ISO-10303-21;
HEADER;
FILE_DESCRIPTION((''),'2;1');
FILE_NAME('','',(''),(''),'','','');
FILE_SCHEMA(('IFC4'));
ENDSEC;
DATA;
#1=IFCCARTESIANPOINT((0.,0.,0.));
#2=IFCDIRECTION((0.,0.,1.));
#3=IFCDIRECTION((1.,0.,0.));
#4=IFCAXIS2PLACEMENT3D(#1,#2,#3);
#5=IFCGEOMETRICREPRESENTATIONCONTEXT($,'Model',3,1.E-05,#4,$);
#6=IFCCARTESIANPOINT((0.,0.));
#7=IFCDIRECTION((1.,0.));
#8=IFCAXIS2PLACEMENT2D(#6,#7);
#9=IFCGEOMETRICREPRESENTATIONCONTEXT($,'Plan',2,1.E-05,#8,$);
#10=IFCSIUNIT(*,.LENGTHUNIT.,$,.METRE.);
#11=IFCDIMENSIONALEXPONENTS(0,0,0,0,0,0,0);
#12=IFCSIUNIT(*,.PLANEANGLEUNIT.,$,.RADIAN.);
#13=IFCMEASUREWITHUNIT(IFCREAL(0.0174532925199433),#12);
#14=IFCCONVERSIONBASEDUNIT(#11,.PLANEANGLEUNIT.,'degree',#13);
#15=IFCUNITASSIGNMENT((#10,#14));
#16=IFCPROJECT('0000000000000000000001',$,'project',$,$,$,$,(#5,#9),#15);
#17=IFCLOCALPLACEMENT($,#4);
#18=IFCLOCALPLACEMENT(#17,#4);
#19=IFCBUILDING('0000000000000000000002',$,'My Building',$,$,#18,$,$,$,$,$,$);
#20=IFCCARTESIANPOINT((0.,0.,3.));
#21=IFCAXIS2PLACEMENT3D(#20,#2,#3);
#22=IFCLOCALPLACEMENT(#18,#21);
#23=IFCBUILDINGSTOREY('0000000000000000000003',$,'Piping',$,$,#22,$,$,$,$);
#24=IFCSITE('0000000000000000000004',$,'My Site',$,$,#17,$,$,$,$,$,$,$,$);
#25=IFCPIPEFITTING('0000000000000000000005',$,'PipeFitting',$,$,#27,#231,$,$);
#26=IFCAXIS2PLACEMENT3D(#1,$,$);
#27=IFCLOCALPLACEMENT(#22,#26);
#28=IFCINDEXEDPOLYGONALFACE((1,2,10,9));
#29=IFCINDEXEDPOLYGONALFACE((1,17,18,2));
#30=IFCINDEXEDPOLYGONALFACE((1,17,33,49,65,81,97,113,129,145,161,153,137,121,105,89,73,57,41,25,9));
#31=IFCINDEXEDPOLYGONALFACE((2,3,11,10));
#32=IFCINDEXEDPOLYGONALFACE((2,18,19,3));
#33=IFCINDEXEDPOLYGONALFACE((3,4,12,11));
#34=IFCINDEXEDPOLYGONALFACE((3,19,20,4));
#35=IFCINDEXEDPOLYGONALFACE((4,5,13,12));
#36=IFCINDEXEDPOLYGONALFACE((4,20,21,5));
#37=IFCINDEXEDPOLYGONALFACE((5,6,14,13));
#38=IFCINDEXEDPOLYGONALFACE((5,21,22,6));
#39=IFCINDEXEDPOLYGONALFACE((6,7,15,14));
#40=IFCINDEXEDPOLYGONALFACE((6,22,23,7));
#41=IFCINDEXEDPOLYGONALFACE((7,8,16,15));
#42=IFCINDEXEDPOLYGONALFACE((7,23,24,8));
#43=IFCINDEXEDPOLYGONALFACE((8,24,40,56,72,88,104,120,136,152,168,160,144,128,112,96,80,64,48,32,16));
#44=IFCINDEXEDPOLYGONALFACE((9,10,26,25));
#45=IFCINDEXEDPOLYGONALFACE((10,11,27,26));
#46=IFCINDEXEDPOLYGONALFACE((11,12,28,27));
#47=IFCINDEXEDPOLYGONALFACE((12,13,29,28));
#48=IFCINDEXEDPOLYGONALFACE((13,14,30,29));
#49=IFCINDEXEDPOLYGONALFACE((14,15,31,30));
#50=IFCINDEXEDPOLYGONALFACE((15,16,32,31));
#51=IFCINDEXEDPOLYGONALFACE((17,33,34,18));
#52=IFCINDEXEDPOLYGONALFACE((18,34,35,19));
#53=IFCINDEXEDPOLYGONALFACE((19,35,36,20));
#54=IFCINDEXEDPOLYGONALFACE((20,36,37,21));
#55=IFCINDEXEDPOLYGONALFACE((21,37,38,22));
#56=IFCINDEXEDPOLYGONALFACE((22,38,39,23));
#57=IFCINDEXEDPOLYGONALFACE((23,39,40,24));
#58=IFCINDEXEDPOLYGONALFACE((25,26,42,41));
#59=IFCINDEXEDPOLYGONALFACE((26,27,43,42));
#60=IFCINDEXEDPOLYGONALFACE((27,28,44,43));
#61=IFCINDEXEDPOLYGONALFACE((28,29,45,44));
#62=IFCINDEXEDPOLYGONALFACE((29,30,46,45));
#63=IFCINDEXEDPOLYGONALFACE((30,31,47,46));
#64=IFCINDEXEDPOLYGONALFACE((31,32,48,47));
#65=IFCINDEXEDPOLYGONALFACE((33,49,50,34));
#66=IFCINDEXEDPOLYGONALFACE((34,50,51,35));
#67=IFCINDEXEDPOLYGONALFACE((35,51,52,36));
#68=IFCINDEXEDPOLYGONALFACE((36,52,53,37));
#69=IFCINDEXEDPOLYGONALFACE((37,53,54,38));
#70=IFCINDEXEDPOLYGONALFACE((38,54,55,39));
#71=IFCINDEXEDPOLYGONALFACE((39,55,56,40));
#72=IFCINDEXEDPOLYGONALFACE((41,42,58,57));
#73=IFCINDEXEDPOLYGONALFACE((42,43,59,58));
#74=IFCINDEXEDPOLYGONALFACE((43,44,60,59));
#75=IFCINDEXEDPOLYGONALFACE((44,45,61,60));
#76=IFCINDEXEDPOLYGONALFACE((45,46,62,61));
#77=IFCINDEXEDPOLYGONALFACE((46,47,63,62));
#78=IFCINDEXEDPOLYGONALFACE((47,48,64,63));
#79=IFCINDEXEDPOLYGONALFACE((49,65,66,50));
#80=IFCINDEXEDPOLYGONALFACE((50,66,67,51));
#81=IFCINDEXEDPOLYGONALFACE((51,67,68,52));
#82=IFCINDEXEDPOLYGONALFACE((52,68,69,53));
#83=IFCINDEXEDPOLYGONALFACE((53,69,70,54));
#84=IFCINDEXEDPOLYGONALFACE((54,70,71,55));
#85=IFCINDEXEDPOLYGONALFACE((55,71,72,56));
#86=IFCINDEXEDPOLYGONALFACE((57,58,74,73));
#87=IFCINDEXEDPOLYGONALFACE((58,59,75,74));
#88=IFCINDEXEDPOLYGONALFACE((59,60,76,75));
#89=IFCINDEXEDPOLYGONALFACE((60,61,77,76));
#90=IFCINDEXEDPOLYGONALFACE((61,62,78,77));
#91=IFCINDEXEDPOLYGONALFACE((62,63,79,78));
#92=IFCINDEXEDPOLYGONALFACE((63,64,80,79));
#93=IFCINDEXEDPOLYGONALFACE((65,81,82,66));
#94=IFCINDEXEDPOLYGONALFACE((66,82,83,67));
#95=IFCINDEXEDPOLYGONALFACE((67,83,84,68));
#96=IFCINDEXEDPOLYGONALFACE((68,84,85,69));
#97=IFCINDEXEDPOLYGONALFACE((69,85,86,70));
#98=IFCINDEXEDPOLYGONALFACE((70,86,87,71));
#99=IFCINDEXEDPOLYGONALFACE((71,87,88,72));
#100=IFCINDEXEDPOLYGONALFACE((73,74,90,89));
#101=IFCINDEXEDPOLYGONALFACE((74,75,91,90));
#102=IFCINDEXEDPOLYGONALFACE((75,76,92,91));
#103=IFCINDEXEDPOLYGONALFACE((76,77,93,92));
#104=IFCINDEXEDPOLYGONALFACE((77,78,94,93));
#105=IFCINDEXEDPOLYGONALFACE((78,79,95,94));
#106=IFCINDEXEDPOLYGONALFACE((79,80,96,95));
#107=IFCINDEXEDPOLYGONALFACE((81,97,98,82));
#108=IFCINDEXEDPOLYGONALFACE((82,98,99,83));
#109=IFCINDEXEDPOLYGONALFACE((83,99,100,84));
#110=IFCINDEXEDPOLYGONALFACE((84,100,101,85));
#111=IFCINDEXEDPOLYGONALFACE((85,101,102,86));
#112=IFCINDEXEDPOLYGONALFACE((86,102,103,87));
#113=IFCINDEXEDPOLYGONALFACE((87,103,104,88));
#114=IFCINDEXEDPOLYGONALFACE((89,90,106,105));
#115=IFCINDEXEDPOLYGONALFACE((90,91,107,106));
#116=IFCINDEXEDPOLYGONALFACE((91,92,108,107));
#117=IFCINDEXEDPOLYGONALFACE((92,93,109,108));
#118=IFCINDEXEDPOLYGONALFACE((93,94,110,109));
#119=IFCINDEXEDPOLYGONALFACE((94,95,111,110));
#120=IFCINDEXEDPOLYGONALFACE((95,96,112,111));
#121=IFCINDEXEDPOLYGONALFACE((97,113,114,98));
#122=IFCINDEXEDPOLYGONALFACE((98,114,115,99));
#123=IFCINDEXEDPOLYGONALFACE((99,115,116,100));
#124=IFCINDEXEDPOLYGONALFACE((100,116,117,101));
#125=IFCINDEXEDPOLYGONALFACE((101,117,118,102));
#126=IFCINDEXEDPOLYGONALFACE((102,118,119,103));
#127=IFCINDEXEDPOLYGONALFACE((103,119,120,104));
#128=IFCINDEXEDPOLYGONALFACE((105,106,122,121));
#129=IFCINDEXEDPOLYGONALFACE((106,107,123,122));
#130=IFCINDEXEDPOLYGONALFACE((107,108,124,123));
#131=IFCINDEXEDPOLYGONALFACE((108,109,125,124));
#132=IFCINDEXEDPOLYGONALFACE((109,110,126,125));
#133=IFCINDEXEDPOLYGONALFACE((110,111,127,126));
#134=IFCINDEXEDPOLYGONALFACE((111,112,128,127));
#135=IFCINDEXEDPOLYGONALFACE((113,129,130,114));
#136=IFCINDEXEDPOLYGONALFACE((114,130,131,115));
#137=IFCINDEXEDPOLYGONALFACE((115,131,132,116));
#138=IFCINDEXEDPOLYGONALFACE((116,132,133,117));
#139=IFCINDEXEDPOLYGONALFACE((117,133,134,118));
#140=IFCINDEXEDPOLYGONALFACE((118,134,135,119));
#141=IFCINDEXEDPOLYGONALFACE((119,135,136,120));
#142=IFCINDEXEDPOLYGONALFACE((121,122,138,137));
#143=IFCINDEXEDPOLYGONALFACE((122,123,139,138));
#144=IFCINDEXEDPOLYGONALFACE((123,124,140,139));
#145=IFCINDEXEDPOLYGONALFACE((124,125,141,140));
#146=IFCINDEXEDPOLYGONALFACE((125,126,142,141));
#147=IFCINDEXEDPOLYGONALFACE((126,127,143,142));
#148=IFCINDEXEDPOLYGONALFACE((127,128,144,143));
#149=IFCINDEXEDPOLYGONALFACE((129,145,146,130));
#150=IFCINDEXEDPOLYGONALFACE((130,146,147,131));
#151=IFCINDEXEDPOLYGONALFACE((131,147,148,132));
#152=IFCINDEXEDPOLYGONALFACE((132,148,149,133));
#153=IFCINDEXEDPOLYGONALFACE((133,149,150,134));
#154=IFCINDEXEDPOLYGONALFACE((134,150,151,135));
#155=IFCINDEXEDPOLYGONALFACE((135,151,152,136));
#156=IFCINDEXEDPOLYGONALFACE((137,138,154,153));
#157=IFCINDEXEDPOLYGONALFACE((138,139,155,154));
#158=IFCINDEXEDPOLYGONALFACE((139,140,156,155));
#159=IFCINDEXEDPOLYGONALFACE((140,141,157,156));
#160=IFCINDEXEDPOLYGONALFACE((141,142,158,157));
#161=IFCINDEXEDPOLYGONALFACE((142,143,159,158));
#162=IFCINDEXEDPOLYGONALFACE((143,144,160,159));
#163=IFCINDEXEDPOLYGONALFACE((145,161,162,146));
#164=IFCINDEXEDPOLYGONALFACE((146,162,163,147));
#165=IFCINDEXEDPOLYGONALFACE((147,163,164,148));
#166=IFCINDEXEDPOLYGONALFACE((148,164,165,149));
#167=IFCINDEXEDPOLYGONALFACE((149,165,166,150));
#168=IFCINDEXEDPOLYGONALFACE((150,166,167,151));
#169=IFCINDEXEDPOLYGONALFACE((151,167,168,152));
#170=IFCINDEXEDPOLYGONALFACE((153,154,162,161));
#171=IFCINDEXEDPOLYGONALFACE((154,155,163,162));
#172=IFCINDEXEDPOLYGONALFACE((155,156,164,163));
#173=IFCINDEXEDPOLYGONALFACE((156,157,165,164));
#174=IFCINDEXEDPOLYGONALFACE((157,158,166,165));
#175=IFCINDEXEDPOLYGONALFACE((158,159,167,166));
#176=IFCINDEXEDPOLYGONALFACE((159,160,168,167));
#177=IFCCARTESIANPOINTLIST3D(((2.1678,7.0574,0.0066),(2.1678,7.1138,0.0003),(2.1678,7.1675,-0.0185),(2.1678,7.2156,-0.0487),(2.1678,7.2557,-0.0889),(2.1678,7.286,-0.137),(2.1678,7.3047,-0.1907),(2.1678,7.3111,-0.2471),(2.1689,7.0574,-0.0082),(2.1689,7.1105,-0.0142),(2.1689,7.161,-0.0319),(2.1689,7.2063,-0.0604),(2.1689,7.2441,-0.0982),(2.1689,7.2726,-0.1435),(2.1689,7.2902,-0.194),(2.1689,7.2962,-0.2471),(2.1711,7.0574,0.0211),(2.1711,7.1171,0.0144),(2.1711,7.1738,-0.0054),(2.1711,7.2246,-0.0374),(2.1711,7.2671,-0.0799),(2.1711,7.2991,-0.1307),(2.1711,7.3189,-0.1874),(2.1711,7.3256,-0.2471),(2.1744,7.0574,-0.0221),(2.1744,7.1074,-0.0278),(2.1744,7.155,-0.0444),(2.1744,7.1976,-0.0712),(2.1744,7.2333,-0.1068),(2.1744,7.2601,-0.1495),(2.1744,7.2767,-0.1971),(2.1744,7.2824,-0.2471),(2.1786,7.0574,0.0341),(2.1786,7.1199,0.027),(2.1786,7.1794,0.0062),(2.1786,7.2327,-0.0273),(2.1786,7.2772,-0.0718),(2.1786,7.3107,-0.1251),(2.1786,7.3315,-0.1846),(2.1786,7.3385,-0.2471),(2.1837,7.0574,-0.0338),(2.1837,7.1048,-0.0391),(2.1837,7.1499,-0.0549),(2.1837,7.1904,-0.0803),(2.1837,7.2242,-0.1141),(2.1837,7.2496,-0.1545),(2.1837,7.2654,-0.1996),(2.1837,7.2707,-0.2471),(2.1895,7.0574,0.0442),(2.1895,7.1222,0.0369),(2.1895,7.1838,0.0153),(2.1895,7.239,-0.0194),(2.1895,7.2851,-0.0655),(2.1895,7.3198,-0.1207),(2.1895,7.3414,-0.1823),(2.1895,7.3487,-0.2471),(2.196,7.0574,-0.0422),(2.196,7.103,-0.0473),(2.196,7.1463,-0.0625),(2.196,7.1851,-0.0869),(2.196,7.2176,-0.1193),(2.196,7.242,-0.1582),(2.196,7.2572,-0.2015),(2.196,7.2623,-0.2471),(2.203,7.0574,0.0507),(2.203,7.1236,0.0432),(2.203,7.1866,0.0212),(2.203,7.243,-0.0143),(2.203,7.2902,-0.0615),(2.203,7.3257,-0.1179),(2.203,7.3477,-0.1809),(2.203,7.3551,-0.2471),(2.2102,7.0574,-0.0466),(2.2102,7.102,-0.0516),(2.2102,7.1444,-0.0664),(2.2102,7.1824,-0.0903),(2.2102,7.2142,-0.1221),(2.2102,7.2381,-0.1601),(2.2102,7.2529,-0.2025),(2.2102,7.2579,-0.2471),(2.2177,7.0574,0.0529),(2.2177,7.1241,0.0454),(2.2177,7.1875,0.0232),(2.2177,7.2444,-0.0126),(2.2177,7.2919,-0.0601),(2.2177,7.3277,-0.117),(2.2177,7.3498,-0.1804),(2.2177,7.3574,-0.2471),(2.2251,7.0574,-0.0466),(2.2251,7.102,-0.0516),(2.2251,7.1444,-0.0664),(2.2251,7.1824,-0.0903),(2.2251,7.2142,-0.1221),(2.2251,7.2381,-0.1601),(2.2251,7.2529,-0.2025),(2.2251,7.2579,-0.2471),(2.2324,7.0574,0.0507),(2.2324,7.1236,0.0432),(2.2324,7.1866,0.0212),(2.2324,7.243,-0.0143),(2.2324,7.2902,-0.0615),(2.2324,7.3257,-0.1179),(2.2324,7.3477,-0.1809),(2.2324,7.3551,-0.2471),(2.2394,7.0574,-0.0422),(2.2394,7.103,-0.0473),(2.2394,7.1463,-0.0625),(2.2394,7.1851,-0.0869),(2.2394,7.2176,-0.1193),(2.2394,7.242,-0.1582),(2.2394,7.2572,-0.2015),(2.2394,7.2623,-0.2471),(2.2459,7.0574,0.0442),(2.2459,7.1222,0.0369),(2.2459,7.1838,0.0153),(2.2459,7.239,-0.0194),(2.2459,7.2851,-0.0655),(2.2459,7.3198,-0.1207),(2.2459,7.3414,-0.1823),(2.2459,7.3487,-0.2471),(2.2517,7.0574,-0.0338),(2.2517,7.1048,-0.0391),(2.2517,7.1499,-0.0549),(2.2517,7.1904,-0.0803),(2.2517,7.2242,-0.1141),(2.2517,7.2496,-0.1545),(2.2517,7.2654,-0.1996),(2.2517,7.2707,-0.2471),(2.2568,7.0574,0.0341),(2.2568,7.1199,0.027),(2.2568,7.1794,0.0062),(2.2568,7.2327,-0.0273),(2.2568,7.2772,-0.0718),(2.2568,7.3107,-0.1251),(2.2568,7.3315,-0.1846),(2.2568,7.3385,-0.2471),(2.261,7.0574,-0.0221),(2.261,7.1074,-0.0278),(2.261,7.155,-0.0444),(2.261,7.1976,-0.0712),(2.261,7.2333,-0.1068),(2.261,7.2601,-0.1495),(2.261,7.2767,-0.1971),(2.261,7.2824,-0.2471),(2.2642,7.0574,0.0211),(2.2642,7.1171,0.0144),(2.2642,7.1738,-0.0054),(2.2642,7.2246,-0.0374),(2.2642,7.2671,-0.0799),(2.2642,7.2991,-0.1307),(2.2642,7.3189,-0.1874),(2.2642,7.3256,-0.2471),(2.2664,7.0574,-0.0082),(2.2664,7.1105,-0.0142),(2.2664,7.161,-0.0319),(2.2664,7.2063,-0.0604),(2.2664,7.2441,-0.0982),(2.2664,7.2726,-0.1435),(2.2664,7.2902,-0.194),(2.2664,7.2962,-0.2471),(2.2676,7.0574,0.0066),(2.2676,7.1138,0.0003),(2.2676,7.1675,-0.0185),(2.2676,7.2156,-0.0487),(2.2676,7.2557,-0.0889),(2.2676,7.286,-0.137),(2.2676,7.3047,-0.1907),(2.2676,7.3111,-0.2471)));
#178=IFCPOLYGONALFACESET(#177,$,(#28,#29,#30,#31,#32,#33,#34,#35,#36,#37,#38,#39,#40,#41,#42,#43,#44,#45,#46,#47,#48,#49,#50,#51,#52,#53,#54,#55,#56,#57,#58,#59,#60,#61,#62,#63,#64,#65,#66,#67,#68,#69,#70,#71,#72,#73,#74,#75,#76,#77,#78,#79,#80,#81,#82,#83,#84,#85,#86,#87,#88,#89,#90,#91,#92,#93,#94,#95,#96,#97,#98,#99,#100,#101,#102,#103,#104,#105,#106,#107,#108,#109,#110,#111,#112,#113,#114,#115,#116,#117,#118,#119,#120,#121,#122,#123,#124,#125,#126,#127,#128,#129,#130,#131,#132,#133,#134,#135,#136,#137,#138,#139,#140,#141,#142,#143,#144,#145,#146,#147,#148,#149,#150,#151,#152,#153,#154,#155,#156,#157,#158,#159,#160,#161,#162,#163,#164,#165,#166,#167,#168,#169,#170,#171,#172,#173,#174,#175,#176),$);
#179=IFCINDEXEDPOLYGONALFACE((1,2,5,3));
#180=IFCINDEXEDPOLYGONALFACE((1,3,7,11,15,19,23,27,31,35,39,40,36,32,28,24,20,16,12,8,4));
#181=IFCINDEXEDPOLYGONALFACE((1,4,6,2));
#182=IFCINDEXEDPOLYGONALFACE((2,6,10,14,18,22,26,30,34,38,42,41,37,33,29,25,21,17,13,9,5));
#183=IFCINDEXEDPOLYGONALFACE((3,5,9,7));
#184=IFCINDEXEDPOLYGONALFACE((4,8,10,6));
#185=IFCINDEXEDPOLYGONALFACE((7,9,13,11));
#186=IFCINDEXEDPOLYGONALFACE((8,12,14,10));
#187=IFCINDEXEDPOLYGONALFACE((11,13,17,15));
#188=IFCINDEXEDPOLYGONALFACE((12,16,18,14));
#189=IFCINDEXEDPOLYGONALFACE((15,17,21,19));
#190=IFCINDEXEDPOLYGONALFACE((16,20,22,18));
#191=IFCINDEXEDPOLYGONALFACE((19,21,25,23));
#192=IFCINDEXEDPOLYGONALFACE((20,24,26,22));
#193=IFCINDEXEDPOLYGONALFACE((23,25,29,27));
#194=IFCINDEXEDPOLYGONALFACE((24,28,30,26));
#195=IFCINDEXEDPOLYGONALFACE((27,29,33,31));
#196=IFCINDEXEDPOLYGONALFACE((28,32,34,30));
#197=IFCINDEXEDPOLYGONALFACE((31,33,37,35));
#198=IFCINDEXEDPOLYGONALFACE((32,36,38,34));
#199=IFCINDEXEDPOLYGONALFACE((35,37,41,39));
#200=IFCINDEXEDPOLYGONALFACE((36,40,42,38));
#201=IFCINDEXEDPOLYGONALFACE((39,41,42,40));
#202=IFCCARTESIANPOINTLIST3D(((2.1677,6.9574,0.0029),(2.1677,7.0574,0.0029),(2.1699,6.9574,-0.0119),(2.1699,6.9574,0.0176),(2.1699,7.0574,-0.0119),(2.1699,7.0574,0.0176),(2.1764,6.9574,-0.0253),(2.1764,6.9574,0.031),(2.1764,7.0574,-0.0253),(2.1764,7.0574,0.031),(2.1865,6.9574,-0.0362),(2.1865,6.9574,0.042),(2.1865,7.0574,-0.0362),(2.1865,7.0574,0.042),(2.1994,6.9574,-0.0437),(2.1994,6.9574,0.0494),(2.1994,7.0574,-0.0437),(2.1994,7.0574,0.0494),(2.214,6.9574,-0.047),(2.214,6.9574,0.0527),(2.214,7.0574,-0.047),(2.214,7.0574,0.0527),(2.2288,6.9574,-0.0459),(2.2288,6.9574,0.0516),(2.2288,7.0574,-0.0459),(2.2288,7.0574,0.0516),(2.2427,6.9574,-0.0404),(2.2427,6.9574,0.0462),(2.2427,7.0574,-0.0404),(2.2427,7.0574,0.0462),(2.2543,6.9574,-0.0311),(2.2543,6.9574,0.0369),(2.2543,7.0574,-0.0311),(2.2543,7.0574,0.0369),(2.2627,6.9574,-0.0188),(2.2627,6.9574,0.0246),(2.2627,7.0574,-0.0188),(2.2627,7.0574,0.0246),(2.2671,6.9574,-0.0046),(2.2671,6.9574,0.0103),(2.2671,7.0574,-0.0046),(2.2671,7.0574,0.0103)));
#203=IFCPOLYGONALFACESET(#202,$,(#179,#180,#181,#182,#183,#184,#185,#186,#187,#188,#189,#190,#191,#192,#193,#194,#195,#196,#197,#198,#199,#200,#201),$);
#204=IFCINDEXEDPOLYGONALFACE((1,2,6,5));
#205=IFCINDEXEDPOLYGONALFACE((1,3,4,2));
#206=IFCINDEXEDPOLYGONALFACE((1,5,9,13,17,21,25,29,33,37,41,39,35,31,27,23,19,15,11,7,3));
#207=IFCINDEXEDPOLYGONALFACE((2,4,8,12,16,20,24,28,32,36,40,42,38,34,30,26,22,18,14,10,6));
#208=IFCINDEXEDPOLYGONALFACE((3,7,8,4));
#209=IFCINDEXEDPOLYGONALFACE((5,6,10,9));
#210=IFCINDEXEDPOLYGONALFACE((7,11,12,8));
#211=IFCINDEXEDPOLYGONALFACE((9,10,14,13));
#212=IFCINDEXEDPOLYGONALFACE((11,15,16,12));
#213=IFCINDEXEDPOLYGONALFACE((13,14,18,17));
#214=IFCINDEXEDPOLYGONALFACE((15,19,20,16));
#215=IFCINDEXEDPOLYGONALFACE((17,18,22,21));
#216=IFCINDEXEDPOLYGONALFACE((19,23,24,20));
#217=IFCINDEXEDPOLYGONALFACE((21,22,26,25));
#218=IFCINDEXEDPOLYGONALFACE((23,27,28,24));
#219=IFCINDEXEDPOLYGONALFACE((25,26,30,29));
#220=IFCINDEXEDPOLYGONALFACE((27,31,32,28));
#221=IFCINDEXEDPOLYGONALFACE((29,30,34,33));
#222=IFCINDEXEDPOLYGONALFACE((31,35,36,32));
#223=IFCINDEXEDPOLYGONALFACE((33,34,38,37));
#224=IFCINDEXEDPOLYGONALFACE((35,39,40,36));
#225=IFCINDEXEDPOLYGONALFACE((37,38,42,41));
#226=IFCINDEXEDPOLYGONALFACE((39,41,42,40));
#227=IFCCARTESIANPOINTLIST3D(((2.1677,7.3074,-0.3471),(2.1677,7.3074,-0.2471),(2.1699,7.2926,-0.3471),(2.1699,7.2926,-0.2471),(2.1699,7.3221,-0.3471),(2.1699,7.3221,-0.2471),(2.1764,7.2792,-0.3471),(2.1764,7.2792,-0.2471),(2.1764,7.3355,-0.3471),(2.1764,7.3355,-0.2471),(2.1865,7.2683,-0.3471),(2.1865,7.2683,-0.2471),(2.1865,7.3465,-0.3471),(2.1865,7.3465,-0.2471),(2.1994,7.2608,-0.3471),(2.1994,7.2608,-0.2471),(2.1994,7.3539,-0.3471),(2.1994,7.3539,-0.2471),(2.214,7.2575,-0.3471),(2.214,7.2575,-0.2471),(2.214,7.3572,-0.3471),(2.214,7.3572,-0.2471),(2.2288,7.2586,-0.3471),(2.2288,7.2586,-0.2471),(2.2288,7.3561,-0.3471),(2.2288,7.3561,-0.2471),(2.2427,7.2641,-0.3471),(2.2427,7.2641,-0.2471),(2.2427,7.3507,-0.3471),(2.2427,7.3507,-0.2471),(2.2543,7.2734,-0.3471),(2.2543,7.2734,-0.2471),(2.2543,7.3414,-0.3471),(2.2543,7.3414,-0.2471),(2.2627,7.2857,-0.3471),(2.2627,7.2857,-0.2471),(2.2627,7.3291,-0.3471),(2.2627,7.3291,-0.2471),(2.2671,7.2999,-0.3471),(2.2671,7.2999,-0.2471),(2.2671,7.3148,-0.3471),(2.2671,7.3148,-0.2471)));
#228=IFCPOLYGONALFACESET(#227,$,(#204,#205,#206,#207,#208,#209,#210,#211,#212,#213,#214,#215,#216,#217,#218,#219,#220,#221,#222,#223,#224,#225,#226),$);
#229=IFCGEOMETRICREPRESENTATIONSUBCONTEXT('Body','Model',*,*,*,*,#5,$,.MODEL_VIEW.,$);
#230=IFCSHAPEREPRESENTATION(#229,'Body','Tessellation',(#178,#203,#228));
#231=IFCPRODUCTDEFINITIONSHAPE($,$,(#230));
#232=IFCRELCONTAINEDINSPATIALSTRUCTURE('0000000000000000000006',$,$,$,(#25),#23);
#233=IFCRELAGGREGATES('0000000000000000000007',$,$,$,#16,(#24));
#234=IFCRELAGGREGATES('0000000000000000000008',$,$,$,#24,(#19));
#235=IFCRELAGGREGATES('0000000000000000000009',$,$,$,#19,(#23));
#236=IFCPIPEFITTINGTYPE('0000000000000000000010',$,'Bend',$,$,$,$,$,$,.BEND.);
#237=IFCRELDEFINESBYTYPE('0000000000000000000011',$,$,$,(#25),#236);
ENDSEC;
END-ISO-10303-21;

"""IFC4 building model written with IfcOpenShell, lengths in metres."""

from ifc_helpers import new_model, entity, si_unit, converted_unit, frame, origin_with_axes, origin_2d_with_axis, place, context, subcontext, project, spatial, circle, extrude, source, transform, mapped, type_object, type_shapes, element, save


model = new_model("IFC4")

# Units and contexts
model_context = context("Model", 3, precision=1e-05, world=origin_with_axes())
plan_context = context("Plan", 2, precision=1e-05, world=origin_2d_with_axis())
body_context = subcontext(model_context, "Body", "Model", "MODEL_VIEW")
ifc_project = project(units=[si_unit("LENGTHUNIT", "METRE"), converted_unit("PLANEANGLEUNIT", "degree", entity("IfcReal", 0.0174532925199433), si_unit("PLANEANGLEUNIT", "RADIAN"), dimensions=[0, 0, 0, 0, 0, 0, 0])], contexts=[model_context, plan_context])

# Site, building, storey
site_placement = place(None, origin_with_axes())
site = spatial("IfcSite", under=ifc_project, at=site_placement, Name="My Site")
building_placement = place(site_placement, origin_with_axes())
building = spatial("IfcBuilding", under=site, at=building_placement, Name="My Building")
storey_placement = place(building_placement, frame((0.0, 0.0, 3.0), z_axis=(0.0, 0.0, 1.0), x_axis=(1.0, 0.0, 0.0)))
storey = spatial("IfcBuildingStorey", under=building, at=storey_placement, Name="Piping")

# Pipe fitting
pipe_fitting_type_1 = type_object("IfcPipeFittingType", Name="Bend", PredefinedType="BEND")
shared_shape = source(origin_with_axes(), body_context, "Body", "SolidModel", [
    entity("IfcSweptDiskSolid", entity("IfcIndexedPolyCurve", entity("IfcCartesianPointList3D", [[0.0, 0.0, -0.1], [0.0, 0.0732, -0.2768], [0.0, 0.25, -0.35]]), [entity("IfcArcIndex", [1, 2, 3])]), 0.05),
    extrude(circle(Radius=0.05), origin_with_axes(), (0.0, 0.0, -1.0), 0.1),
    extrude(circle(Radius=0.05), frame((0.0, 0.25, -0.35), z_axis=(0.0, 1.0, 0.0), x_axis=(1.0, 0.0, 0.0)), (0.0, 0.0, 1.0), 0.1),
])
type_shapes(pipe_fitting_type_1, [shared_shape])
for number, where, z_axis, x_axis, name in (
    (1, (2.2177, 6.9574, 0.0029), (0.0, -1.0, 0.0), (-1.0, 0.0, 0.0), "PipeFitting"),
):
    element("IfcPipeFitting", number, at=place(storey_placement, frame(where, z_axis=z_axis, x_axis=x_axis)), inside=storey, type_object=pipe_fitting_type_1, Name=name, context=body_context, shape_type="MappedRepresentation", body=[
        mapped(shared_shape, transform((0.0, 0.0, 0.0), x_axis=(1.0, 0.0, 0.0), y_axis=(0.0, 1.0, 0.0), z_axis=(0.0, 0.0, 1.0), scale=1.0)),
    ])

save(model, "model.ifc")
